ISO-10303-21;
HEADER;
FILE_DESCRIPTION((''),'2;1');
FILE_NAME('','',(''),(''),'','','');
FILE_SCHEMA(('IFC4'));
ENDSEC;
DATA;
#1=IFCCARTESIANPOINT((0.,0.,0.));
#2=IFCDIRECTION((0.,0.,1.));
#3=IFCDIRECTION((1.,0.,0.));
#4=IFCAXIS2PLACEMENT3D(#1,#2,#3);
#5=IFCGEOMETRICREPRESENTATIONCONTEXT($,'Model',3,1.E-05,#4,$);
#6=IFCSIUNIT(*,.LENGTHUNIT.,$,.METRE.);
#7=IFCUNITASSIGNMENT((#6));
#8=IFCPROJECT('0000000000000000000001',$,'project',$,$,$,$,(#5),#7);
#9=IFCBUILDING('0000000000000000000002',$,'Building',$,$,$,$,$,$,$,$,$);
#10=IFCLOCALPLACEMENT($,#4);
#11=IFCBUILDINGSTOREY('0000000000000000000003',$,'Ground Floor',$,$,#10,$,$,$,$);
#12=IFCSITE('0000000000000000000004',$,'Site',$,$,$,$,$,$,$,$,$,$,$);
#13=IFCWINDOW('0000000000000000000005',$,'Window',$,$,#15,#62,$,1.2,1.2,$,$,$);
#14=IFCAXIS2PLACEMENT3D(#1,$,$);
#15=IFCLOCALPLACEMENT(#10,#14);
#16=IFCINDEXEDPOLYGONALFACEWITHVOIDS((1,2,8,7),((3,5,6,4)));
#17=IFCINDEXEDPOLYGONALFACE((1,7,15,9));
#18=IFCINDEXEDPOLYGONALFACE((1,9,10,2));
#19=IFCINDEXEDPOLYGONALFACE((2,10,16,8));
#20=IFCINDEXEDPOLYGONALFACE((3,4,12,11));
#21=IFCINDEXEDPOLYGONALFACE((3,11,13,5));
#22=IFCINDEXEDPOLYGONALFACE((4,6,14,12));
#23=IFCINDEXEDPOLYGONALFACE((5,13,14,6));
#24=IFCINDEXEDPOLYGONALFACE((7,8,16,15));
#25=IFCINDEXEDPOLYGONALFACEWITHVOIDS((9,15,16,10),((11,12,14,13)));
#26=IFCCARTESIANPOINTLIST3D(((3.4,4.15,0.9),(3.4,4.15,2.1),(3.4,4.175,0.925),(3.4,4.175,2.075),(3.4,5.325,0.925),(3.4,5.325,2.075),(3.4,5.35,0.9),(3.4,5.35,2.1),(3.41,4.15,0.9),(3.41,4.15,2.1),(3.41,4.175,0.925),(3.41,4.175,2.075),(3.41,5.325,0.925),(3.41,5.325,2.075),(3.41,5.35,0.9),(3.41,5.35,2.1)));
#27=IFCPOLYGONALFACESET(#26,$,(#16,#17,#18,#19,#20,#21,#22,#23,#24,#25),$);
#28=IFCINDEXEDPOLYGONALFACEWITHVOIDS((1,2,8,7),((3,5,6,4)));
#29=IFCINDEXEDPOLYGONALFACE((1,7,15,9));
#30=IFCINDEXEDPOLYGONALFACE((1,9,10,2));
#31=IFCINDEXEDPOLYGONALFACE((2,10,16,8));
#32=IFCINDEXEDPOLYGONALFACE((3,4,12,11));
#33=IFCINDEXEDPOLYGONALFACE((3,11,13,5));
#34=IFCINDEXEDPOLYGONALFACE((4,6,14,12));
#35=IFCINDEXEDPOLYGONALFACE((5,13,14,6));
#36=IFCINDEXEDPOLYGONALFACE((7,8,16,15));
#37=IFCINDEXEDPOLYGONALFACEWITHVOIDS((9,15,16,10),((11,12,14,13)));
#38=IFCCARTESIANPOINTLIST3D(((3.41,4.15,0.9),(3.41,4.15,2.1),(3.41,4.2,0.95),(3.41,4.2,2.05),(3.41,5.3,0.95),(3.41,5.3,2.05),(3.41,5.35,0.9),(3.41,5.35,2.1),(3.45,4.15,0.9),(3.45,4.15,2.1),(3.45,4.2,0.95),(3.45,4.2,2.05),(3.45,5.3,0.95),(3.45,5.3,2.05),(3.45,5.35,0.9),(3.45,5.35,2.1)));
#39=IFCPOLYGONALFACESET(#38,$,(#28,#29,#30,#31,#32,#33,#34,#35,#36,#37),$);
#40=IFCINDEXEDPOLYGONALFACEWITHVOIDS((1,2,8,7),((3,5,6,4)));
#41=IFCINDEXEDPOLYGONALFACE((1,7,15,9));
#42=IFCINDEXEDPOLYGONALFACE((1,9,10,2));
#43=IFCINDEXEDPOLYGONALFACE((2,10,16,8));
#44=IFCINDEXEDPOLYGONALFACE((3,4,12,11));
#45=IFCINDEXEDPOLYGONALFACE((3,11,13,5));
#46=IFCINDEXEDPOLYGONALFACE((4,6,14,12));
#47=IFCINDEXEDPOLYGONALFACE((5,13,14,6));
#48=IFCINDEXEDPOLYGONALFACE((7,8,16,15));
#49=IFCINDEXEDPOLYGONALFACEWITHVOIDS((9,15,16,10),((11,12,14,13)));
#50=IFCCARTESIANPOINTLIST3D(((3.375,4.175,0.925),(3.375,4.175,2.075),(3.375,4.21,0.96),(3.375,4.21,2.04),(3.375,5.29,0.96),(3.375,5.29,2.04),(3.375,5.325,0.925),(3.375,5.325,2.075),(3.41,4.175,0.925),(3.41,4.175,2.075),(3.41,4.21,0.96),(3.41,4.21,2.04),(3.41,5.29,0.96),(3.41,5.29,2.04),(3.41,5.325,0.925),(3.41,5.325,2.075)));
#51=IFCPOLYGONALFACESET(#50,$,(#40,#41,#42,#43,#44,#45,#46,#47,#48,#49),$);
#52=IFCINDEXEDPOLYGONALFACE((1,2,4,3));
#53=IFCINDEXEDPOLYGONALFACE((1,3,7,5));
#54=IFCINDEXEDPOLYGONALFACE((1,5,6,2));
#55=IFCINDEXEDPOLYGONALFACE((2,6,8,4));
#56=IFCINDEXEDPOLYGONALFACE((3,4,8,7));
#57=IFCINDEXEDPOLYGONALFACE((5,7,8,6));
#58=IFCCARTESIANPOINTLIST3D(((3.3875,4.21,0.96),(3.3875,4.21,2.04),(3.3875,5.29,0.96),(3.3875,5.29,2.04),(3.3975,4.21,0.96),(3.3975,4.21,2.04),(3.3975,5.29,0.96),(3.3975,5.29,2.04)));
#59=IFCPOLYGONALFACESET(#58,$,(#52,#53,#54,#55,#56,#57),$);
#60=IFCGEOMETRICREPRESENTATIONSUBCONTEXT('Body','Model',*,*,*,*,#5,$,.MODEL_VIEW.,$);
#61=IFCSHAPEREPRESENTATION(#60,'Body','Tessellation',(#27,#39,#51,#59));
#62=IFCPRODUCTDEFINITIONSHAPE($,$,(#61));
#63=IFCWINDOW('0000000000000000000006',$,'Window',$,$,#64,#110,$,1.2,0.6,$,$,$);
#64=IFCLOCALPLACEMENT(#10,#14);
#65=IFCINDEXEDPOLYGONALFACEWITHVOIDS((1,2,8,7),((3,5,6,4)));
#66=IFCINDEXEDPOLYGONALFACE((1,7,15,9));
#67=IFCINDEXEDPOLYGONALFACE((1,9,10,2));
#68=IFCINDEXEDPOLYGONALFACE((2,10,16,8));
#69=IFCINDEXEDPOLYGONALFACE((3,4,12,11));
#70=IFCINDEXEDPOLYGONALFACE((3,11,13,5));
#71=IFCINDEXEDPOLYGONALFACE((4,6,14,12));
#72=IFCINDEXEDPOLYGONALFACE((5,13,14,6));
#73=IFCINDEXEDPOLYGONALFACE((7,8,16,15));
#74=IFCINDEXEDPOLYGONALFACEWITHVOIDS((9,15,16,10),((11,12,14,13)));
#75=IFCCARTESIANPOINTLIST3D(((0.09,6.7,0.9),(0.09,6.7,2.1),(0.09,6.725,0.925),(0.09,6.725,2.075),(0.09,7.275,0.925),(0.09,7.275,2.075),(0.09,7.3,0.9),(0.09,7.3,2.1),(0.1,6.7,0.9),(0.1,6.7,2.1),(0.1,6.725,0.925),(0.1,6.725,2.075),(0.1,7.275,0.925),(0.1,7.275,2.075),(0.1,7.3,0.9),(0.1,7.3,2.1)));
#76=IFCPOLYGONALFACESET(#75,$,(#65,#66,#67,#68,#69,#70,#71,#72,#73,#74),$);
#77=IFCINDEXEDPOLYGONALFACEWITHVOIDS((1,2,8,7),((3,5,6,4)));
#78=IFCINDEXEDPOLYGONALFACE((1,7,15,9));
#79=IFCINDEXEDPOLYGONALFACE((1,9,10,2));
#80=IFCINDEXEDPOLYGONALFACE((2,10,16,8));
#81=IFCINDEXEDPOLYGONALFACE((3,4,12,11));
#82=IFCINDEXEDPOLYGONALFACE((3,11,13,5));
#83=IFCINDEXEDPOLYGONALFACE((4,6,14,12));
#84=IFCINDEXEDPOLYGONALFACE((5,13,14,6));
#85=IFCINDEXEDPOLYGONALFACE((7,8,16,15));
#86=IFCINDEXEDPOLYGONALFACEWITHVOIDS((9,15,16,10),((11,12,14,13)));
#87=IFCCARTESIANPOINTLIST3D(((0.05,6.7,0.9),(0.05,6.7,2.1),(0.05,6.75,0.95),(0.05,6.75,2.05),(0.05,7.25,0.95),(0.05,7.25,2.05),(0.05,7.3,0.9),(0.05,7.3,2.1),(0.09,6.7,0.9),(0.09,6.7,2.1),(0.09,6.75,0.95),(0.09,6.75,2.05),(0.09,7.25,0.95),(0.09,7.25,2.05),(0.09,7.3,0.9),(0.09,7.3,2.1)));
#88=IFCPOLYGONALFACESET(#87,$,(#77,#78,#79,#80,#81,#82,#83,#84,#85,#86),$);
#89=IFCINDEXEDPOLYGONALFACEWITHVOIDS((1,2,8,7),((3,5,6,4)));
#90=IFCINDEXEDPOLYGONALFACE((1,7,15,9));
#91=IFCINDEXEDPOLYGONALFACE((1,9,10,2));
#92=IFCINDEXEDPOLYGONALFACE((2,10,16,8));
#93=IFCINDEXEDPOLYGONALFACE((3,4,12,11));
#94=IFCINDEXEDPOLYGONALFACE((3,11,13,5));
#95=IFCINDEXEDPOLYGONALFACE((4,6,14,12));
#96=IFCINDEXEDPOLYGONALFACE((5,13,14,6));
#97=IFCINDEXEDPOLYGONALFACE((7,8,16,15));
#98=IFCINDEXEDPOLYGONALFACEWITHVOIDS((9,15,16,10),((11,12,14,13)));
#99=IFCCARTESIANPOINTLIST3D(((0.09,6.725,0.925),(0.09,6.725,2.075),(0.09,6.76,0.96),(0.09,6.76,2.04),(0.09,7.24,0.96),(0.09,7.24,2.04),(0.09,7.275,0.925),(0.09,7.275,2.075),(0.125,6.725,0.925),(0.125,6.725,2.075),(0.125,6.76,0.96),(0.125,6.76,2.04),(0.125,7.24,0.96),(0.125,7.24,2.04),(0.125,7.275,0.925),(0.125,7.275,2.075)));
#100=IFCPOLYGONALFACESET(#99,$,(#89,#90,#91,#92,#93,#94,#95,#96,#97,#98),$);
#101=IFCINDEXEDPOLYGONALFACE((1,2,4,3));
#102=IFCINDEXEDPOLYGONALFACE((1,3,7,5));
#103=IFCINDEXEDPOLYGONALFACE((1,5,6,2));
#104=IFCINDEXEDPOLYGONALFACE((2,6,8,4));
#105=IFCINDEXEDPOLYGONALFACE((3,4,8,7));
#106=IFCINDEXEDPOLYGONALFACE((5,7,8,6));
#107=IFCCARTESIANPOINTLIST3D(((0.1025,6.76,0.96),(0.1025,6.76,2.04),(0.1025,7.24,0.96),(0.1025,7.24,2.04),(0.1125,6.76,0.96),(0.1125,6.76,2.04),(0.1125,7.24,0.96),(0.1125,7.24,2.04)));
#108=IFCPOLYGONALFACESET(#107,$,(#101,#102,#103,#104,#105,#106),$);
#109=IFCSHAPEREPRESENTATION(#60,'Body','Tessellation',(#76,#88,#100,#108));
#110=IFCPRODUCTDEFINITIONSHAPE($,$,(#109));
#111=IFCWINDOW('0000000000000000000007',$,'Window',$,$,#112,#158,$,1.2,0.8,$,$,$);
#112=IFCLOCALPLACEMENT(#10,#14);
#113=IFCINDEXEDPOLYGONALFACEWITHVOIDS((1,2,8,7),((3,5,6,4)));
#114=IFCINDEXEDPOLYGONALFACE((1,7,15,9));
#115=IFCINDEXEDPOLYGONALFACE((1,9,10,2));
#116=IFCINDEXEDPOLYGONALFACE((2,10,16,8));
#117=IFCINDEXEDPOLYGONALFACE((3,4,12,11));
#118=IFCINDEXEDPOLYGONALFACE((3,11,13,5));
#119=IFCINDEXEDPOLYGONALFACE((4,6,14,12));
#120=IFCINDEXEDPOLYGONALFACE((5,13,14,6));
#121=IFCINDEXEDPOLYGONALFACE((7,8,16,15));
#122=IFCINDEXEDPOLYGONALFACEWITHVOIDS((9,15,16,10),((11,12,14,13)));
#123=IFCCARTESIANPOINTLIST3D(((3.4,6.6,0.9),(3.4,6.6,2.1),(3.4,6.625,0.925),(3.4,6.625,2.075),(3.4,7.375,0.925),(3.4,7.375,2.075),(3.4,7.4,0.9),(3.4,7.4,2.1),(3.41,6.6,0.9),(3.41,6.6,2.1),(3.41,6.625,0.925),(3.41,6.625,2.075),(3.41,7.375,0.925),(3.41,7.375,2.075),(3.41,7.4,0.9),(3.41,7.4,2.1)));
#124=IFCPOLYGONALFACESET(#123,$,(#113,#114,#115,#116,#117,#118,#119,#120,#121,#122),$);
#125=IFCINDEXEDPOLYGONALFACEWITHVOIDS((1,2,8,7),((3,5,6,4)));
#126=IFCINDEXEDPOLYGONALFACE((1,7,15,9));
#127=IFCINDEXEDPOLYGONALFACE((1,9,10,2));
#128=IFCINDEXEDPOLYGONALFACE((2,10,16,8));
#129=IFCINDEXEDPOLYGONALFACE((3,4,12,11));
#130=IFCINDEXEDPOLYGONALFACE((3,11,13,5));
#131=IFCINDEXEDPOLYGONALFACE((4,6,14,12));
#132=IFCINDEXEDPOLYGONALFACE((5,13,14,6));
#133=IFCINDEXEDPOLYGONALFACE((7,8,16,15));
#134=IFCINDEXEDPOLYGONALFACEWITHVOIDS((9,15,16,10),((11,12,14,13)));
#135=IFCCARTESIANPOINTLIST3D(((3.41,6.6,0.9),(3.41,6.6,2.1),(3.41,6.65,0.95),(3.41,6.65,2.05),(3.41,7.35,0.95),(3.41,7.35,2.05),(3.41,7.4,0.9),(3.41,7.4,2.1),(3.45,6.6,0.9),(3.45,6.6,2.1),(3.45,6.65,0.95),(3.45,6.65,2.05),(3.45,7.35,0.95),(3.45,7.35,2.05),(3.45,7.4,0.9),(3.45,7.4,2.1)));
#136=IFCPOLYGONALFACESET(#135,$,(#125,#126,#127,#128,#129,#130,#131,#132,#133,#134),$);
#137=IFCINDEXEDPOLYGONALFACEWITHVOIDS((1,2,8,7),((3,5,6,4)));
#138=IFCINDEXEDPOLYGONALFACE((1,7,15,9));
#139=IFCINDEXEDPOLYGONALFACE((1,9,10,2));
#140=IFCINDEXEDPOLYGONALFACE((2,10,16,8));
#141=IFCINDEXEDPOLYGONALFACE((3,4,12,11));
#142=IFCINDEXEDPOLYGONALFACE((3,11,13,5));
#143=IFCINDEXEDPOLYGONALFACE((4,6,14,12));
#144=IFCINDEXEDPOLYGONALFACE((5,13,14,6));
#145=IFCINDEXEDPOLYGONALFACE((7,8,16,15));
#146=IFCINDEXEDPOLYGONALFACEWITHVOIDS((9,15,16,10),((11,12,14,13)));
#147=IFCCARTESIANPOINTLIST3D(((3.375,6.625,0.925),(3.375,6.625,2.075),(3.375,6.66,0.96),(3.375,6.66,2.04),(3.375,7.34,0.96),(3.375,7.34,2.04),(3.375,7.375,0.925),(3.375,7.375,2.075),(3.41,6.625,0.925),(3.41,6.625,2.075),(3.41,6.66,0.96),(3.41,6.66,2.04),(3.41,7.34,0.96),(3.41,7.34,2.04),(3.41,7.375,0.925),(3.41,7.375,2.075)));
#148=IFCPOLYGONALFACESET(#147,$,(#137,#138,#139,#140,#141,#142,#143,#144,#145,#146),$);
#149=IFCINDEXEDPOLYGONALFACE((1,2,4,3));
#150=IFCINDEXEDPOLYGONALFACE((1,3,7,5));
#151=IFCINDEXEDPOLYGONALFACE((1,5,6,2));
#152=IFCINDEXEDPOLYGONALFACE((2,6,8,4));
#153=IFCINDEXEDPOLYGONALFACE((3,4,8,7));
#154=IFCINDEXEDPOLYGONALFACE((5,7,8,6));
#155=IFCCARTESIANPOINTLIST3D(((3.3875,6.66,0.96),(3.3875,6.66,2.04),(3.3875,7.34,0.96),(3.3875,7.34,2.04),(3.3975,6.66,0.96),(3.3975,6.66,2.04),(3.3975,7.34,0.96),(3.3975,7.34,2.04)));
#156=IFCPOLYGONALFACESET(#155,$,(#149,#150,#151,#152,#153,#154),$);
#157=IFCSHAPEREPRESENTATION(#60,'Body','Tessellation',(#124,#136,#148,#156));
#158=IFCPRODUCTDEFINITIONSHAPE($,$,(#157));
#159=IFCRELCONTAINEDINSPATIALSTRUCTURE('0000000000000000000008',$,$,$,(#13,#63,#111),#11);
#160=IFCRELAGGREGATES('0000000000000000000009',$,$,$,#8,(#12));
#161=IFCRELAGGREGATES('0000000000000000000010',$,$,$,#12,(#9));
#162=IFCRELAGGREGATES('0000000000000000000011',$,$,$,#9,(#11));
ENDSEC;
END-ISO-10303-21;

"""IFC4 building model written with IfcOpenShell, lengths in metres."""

from ifc_helpers import new_model, si_unit, frame, origin_with_axes, place, context, subcontext, project, spatial, line, indexed_curve, outline, extrude, element, save


model = new_model("IFC4")

# Units and contexts
model_context = context("Model", 3, precision=1e-05, world=origin_with_axes())
body_context = subcontext(model_context, "Body", "Model", "MODEL_VIEW")
ifc_project = project(units=[si_unit("LENGTHUNIT", "METRE")], contexts=[model_context])

# Site, building, storey
site = spatial("IfcSite", under=ifc_project, Name="Site")
building = spatial("IfcBuilding", under=site, Name="Building")
storey_placement = place(None, origin_with_axes())
storey = spatial("IfcBuildingStorey", under=building, at=storey_placement, Name="Ground Floor")

# Windows
window_1_placement = place(storey_placement, frame((3.5, 4.15, 0.9), z_axis=(0.0, 0.0, 1.0), x_axis=(0.0, 1.0, 0.0)))
element("IfcWindow", 1, at=window_1_placement, inside=storey, Name="Window", OverallHeight=1.2, OverallWidth=1.2, context=body_context, shape_type="SweptSolid", body=[
    extrude(outline(indexed_curve([(0.0, 0.0), (1.2, 0.0), (1.2, 1.2), (0.0, 1.2)], segments=[line(1, 2, 3, 4, 1)]), holes=[indexed_curve([(0.025, 0.025), (1.175, 0.025), (1.175, 1.175), (0.025, 1.175)], segments=[line(1, 2, 3, 4, 1)])]), frame((0.0, 0.09, 0.0), z_axis=(0.0, -1.0, 0.0), x_axis=(1.0, 0.0, 0.0)), (0.0, 0.0, -1.0), 0.01),
    extrude(outline(indexed_curve([(0.0, 0.0), (1.2, 0.0), (1.2, 1.2), (0.0, 1.2)], segments=[line(1, 2, 3, 4, 1)]), holes=[indexed_curve([(0.05, 0.05), (1.15, 0.05), (1.15, 1.15), (0.05, 1.15)], segments=[line(1, 2, 3, 4, 1)])]), frame((0.0, 0.05, 0.0), z_axis=(0.0, -1.0, 0.0), x_axis=(1.0, 0.0, 0.0)), (0.0, 0.0, -1.0), 0.04),
    extrude(outline(indexed_curve([(0.0, 0.0), (1.15, 0.0), (1.15, 1.15), (0.0, 1.15)], segments=[line(1, 2, 3, 4, 1)]), holes=[indexed_curve([(0.035, 0.035), (1.115, 0.035), (1.115, 1.115), (0.035, 1.115)], segments=[line(1, 2, 3, 4, 1)])]), frame((0.025, 0.09, 0.025), z_axis=(0.0, -1.0, 0.0), x_axis=(1.0, 0.0, 0.0)), (0.0, 0.0, -1.0), 0.035),
    extrude(outline(indexed_curve([(0.035, 0.035), (1.115, 0.035), (1.115, 1.115), (0.035, 1.115)], segments=[line(1, 2, 3, 4, 1)])), frame((0.025, 0.1025, 0.025), z_axis=(0.0, -1.0, 0.0), x_axis=(1.0, 0.0, 0.0)), (0.0, 0.0, -1.0), 0.01),
])
window_2_placement = place(storey_placement, frame((0.0, 7.3, 0.9), z_axis=(0.0, 0.0, 1.0), x_axis=(0.0, -1.0, 0.0)))
element("IfcWindow", 2, at=window_2_placement, inside=storey, Name="Window", OverallHeight=1.2, OverallWidth=0.6, context=body_context, shape_type="SweptSolid", body=[
    extrude(outline(indexed_curve([(0.0, 0.0), (0.6, 0.0), (0.6, 1.2), (0.0, 1.2)], segments=[line(1, 2, 3, 4, 1)]), holes=[indexed_curve([(0.025, 0.025), (0.575, 0.025), (0.575, 1.175), (0.025, 1.175)], segments=[line(1, 2, 3, 4, 1)])]), frame((0.0, 0.09, 0.0), z_axis=(0.0, -1.0, 0.0), x_axis=(1.0, 0.0, 0.0)), (0.0, 0.0, -1.0), 0.01),
    extrude(outline(indexed_curve([(0.0, 0.0), (0.6, 0.0), (0.6, 1.2), (0.0, 1.2)], segments=[line(1, 2, 3, 4, 1)]), holes=[indexed_curve([(0.05, 0.05), (0.55, 0.05), (0.55, 1.15), (0.05, 1.15)], segments=[line(1, 2, 3, 4, 1)])]), frame((0.0, 0.05, 0.0), z_axis=(0.0, -1.0, 0.0), x_axis=(1.0, 0.0, 0.0)), (0.0, 0.0, -1.0), 0.04),
    extrude(outline(indexed_curve([(0.0, 0.0), (0.55, 0.0), (0.55, 1.15), (0.0, 1.15)], segments=[line(1, 2, 3, 4, 1)]), holes=[indexed_curve([(0.035, 0.035), (0.515, 0.035), (0.515, 1.115), (0.035, 1.115)], segments=[line(1, 2, 3, 4, 1)])]), frame((0.025, 0.09, 0.025), z_axis=(0.0, -1.0, 0.0), x_axis=(1.0, 0.0, 0.0)), (0.0, 0.0, -1.0), 0.035),
    extrude(outline(indexed_curve([(0.035, 0.035), (0.515, 0.035), (0.515, 1.115), (0.035, 1.115)], segments=[line(1, 2, 3, 4, 1)])), frame((0.025, 0.1025, 0.025), z_axis=(0.0, -1.0, 0.0), x_axis=(1.0, 0.0, 0.0)), (0.0, 0.0, -1.0), 0.01),
])
window_3_placement = place(storey_placement, frame((3.5, 6.6, 0.9), z_axis=(0.0, 0.0, 1.0), x_axis=(0.0, 1.0, 0.0)))
element("IfcWindow", 3, at=window_3_placement, inside=storey, Name="Window", OverallHeight=1.2, OverallWidth=0.8, context=body_context, shape_type="SweptSolid", body=[
    extrude(outline(indexed_curve([(0.0, 0.0), (0.8, 0.0), (0.8, 1.2), (0.0, 1.2)], segments=[line(1, 2, 3, 4, 1)]), holes=[indexed_curve([(0.025, 0.025), (0.775, 0.025), (0.775, 1.175), (0.025, 1.175)], segments=[line(1, 2, 3, 4, 1)])]), frame((0.0, 0.09, 0.0), z_axis=(0.0, -1.0, 0.0), x_axis=(1.0, 0.0, 0.0)), (0.0, 0.0, -1.0), 0.01),
    extrude(outline(indexed_curve([(0.0, 0.0), (0.8, 0.0), (0.8, 1.2), (0.0, 1.2)], segments=[line(1, 2, 3, 4, 1)]), holes=[indexed_curve([(0.05, 0.05), (0.75, 0.05), (0.75, 1.15), (0.05, 1.15)], segments=[line(1, 2, 3, 4, 1)])]), frame((0.0, 0.05, 0.0), z_axis=(0.0, -1.0, 0.0), x_axis=(1.0, 0.0, 0.0)), (0.0, 0.0, -1.0), 0.04),
    extrude(outline(indexed_curve([(0.0, 0.0), (0.75, 0.0), (0.75, 1.15), (0.0, 1.15)], segments=[line(1, 2, 3, 4, 1)]), holes=[indexed_curve([(0.035, 0.035), (0.715, 0.035), (0.715, 1.115), (0.035, 1.115)], segments=[line(1, 2, 3, 4, 1)])]), frame((0.025, 0.09, 0.025), z_axis=(0.0, -1.0, 0.0), x_axis=(1.0, 0.0, 0.0)), (0.0, 0.0, -1.0), 0.035),
    extrude(outline(indexed_curve([(0.035, 0.035), (0.715, 0.035), (0.715, 1.115), (0.035, 1.115)], segments=[line(1, 2, 3, 4, 1)])), frame((0.025, 0.1025, 0.025), z_axis=(0.0, -1.0, 0.0), x_axis=(1.0, 0.0, 0.0)), (0.0, 0.0, -1.0), 0.01),
])

save(model, "model.ifc")
